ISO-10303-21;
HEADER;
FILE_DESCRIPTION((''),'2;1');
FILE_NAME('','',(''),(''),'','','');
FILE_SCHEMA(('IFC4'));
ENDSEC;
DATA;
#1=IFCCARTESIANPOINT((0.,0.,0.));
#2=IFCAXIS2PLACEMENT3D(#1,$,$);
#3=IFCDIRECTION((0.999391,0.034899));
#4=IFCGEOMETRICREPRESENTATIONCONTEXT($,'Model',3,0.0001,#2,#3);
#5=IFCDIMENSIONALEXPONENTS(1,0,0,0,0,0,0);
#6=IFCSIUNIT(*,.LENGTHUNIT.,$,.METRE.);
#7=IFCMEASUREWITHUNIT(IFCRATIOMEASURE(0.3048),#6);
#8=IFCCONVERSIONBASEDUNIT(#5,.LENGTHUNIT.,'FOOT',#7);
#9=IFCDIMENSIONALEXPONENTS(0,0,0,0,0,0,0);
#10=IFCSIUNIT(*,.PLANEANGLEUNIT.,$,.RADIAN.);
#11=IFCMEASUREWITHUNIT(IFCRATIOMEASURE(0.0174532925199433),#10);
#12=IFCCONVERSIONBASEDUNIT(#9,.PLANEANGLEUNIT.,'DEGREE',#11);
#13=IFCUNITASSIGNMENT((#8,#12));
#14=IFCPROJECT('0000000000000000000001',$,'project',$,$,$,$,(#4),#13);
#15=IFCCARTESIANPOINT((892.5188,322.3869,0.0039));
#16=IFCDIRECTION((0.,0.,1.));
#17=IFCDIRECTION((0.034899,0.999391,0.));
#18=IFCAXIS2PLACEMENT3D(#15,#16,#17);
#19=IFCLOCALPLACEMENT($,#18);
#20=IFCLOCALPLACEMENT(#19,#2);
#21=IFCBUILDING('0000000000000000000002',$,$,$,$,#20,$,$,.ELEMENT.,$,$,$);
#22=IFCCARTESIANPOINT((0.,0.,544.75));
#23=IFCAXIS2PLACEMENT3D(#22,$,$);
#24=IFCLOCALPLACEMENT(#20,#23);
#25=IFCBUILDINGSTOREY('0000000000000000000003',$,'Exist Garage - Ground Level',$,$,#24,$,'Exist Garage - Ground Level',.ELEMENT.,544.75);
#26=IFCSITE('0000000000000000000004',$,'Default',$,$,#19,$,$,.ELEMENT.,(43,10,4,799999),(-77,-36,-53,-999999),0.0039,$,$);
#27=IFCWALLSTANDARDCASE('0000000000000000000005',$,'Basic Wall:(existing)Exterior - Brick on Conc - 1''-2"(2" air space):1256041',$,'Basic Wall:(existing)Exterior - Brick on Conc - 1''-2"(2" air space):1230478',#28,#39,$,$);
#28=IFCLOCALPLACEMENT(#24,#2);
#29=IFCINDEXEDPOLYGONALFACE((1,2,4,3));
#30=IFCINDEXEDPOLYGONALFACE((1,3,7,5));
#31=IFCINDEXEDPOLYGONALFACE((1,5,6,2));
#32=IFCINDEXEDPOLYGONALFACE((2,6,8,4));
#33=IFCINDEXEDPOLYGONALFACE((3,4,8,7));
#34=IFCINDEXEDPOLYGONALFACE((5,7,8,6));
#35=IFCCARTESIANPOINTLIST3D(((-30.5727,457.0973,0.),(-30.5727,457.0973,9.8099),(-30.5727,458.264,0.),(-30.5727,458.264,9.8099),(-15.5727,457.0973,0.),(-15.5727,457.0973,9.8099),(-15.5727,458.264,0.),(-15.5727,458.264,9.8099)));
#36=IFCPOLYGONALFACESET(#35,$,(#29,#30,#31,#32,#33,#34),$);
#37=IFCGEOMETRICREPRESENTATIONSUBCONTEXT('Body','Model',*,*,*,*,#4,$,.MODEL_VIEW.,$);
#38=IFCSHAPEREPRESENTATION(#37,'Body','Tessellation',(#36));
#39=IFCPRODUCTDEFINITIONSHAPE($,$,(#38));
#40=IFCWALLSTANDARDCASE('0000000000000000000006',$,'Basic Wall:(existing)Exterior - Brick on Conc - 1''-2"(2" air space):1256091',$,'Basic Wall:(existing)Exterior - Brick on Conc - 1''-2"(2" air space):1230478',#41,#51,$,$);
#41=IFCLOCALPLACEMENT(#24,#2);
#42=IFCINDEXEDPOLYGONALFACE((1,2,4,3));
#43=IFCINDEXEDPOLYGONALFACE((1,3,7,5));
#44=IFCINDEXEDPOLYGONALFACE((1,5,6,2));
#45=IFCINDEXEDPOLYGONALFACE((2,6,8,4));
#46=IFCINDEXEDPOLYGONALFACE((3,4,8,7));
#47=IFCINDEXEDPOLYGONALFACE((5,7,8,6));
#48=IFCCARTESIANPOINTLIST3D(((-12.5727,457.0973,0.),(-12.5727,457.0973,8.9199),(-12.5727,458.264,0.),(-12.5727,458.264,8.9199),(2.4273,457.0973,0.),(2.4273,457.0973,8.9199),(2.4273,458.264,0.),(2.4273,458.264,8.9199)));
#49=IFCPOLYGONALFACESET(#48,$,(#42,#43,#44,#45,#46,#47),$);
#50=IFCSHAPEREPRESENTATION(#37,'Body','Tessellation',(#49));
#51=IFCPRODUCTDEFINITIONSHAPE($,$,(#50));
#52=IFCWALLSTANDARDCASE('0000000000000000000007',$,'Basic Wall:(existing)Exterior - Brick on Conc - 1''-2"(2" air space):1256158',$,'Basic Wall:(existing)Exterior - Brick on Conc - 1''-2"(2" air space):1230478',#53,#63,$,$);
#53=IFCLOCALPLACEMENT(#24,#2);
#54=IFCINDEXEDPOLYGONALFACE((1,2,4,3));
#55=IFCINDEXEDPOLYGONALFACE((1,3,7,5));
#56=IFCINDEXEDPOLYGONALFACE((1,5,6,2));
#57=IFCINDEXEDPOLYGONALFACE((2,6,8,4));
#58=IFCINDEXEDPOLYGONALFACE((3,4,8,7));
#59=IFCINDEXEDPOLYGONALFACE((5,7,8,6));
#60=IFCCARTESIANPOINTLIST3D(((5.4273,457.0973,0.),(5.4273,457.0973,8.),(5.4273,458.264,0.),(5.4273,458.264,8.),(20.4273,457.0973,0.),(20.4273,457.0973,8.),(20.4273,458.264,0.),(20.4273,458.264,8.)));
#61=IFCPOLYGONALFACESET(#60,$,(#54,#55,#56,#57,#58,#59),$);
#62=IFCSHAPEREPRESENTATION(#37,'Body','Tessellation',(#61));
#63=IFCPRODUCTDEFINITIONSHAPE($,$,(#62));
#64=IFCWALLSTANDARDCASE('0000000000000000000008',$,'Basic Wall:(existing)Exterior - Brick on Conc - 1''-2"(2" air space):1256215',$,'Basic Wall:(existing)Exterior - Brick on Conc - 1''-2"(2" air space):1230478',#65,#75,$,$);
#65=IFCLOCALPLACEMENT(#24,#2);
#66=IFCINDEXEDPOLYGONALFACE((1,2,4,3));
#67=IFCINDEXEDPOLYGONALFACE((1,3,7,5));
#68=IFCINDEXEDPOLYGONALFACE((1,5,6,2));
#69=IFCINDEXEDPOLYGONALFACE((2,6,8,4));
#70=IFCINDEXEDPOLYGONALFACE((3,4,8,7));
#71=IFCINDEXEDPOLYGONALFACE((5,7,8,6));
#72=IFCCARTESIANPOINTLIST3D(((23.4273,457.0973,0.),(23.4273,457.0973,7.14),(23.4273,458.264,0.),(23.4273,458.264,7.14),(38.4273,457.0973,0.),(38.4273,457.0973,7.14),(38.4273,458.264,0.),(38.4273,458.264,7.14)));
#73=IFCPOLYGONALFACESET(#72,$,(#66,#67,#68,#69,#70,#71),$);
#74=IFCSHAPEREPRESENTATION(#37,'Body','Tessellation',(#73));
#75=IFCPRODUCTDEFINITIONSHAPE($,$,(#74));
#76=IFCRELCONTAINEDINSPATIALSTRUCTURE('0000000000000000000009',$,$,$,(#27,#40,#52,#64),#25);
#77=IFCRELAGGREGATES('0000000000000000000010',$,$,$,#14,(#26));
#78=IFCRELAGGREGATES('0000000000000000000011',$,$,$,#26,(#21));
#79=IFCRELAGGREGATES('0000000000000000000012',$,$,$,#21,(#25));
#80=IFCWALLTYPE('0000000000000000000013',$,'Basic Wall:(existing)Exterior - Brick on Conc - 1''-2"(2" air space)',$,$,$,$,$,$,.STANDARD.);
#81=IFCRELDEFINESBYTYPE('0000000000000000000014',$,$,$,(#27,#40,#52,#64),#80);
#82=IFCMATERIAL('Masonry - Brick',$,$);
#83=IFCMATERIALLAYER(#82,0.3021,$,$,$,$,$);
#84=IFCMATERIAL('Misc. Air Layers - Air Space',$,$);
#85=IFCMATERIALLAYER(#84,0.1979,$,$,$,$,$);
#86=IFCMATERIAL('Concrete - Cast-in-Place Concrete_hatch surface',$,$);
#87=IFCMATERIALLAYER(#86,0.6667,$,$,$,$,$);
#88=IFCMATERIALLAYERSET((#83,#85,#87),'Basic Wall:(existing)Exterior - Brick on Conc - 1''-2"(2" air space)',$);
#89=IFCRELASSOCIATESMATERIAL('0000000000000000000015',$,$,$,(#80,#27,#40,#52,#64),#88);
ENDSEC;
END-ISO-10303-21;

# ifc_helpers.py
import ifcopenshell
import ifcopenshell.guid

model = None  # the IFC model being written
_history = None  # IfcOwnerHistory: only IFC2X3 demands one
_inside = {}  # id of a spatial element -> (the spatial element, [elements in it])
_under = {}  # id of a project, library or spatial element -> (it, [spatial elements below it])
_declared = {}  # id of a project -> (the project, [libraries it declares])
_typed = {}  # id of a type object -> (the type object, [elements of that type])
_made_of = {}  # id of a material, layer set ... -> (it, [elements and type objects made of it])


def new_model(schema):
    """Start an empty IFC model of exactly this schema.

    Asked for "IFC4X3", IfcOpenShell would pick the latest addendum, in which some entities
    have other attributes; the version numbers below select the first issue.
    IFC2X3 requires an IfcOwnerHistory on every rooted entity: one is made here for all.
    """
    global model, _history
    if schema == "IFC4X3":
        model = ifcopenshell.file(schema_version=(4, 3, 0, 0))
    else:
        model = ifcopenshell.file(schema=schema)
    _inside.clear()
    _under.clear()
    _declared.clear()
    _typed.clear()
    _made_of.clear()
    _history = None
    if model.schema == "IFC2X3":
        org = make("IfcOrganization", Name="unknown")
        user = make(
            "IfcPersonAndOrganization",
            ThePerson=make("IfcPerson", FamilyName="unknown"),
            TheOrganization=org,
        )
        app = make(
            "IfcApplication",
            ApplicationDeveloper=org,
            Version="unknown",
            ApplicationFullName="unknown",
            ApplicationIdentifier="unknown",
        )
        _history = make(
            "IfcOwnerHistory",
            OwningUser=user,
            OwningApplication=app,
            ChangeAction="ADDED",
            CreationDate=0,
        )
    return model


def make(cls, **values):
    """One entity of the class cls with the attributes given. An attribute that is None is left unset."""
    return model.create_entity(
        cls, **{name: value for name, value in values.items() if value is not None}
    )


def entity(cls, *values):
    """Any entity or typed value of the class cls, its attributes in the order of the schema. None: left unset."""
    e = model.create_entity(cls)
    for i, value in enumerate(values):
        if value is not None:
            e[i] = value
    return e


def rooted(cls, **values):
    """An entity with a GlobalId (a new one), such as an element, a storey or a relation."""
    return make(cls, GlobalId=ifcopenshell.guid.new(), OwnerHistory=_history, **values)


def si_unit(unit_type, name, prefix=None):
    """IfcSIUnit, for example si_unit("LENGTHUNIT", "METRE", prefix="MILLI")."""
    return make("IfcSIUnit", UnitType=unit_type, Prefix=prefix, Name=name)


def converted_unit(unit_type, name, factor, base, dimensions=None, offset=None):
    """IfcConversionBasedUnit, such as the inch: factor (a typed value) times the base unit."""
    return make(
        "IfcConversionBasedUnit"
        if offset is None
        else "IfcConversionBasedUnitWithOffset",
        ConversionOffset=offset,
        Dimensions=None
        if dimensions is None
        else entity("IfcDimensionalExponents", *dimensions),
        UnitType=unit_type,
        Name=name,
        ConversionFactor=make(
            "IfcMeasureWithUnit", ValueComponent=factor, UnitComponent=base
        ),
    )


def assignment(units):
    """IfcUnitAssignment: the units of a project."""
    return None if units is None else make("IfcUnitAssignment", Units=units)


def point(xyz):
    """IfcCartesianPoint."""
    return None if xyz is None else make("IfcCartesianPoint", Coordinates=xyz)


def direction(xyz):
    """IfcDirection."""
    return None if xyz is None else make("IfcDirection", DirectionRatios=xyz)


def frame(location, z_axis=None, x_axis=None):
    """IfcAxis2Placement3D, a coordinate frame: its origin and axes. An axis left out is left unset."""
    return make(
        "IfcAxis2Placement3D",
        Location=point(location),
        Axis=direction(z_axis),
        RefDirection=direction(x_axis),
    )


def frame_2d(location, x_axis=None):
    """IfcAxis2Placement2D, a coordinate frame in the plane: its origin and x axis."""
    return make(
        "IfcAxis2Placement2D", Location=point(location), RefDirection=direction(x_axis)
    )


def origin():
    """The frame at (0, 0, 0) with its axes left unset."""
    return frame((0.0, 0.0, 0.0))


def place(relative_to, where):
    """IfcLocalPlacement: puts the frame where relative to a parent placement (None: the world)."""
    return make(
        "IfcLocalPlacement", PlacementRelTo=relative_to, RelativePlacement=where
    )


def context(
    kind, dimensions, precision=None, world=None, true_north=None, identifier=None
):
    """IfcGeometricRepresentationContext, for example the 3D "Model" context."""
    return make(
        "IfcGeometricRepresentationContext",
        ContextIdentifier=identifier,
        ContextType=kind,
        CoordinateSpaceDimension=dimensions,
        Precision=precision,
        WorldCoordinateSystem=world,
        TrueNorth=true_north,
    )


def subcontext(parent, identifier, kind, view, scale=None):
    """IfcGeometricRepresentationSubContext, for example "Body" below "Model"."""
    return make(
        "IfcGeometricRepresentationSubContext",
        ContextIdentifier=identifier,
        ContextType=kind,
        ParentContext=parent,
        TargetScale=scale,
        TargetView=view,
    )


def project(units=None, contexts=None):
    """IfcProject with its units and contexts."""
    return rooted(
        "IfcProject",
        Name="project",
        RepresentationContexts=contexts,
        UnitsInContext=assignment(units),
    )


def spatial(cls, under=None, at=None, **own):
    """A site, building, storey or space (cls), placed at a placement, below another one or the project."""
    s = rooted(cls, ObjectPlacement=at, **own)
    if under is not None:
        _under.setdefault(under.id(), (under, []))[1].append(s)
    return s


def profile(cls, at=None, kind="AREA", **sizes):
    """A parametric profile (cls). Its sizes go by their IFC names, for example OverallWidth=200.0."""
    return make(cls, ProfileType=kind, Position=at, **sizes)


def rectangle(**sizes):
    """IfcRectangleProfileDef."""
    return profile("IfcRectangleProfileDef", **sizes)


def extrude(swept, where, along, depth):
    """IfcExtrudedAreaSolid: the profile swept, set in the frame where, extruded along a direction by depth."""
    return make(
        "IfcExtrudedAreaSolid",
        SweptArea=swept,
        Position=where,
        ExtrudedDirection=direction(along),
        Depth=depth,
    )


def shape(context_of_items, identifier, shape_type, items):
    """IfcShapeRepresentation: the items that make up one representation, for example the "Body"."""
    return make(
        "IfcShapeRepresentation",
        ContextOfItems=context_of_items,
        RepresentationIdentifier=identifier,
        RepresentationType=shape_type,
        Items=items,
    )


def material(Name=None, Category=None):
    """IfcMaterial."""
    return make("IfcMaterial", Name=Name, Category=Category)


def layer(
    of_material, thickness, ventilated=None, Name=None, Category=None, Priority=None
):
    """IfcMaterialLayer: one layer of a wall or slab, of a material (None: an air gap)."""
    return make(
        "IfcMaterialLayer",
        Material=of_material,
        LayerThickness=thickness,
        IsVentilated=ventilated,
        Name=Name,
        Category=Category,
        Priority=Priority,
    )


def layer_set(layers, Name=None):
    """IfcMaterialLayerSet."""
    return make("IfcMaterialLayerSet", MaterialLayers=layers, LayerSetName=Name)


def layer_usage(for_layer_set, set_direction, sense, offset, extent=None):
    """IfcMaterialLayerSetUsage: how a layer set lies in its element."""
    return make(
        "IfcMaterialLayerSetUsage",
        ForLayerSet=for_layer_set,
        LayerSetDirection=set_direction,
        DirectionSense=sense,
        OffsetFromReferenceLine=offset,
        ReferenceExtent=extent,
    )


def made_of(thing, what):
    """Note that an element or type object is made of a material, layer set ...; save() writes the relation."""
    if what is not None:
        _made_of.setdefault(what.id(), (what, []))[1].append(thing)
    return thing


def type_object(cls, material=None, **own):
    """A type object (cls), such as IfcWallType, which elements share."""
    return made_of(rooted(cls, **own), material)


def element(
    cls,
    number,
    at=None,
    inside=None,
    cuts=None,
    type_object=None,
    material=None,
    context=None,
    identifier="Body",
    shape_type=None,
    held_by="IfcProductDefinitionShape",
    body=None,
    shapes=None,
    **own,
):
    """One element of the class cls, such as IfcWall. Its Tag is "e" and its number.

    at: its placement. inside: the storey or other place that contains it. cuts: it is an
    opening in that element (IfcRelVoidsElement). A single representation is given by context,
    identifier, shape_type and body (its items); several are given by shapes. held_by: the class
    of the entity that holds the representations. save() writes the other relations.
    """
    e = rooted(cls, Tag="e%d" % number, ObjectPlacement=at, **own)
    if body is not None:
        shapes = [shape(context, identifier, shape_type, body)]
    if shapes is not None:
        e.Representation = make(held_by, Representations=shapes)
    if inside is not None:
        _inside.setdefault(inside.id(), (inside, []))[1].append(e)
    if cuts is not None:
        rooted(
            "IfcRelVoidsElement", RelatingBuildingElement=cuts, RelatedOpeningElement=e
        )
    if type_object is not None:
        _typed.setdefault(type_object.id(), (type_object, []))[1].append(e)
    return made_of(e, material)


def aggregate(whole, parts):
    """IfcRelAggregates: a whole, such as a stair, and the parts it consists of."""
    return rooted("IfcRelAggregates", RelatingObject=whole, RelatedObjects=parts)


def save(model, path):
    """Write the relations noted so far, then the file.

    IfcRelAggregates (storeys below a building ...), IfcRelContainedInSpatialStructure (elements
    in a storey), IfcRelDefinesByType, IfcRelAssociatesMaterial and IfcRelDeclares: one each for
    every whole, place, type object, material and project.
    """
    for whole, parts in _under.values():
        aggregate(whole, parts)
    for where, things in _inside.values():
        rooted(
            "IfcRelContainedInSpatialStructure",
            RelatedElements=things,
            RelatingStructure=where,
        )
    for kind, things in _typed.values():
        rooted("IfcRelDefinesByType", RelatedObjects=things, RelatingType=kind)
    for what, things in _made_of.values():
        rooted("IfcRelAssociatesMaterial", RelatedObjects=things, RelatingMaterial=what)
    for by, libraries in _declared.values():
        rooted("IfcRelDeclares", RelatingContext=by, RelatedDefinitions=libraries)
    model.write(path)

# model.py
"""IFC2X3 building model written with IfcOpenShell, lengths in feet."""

from ifc_helpers import new_model, entity, si_unit, converted_unit, direction, frame, frame_2d, origin, place, context, subcontext, project, spatial, rectangle, extrude, material, layer, layer_set, layer_usage, type_object, element, save


model = new_model("IFC2X3")

# Units and contexts
model_context = context("Model", 3, precision=0.0001, world=origin(), true_north=direction((0.999391, 0.034899)))
body_context = subcontext(model_context, "Body", "Model", "MODEL_VIEW")
ifc_project = project(units=[converted_unit("LENGTHUNIT", "FOOT", entity("IfcRatioMeasure", 0.3048), si_unit("LENGTHUNIT", "METRE"), dimensions=[1, 0, 0, 0, 0, 0, 0]), converted_unit("PLANEANGLEUNIT", "DEGREE", entity("IfcRatioMeasure", 0.0174532925199433), si_unit("PLANEANGLEUNIT", "RADIAN"), dimensions=[0, 0, 0, 0, 0, 0, 0])], contexts=[model_context])

# Site, building, storey
site_placement = place(None, frame((892.5188, 322.3869, 0.0039), z_axis=(0.0, 0.0, 1.0), x_axis=(0.034899, 0.999391, 0.0)))
site = spatial("IfcSite", under=ifc_project, at=site_placement, Name="Default", CompositionType="ELEMENT", RefLatitude=(43, 10, 4, 799999), RefLongitude=(-77, -36, -53, -999999), RefElevation=0.0039)
building_placement = place(site_placement, origin())
building = spatial("IfcBuilding", under=site, at=building_placement, CompositionType="ELEMENT")
storey_placement = place(building_placement, frame((0.0, 0.0, 544.75)))
storey = spatial("IfcBuildingStorey", under=building, at=storey_placement, Name="Exist Garage - Ground Level", LongName="Exist Garage - Ground Level", CompositionType="ELEMENT", Elevation=544.75)

# Walls
ifc_material_1 = material(Name="Masonry - Brick")
ifc_layer_1 = layer(ifc_material_1, 0.3021)
ifc_material_2 = material(Name="Misc. Air Layers - Air Space")
ifc_layer_2 = layer(ifc_material_2, 0.1979)
ifc_material_3 = material(Name="Concrete - Cast-in-Place Concrete_hatch surface")
ifc_layer_3 = layer(ifc_material_3, 0.6667)
ifc_layer_set_1 = layer_set([ifc_layer_1, ifc_layer_2, ifc_layer_3], Name="Basic Wall:(existing)Exterior - Brick on Conc - 1'-2\"(2\" air space)")
wall_type_1 = type_object("IfcWallType", Name="Basic Wall:(existing)Exterior - Brick on Conc - 1'-2\"(2\" air space)", PredefinedType="STANDARD", material=ifc_layer_set_1)
ifc_layer_usage_1 = layer_usage(ifc_layer_set_1, "AXIS2", "POSITIVE", -0.5833)
wall_1_placement = place(storey_placement, frame((-15.5727, 457.6806, 0.0), z_axis=(0.0, 0.0, 1.0), x_axis=(-1.0, 0.0, 0.0)))
element("IfcWallStandardCase", 1, at=wall_1_placement, inside=storey, type_object=wall_type_1, material=ifc_layer_usage_1, Name="Basic Wall:(existing)Exterior - Brick on Conc - 1'-2\"(2\" air space):1256041", ObjectType="Basic Wall:(existing)Exterior - Brick on Conc - 1'-2\"(2\" air space):1230478", context=body_context, shape_type="SweptSolid", body=[
    extrude(rectangle(XDim=15.0, YDim=1.1667, at=frame_2d((7.5, 0.0), x_axis=(-1.0, 0.0))), origin(), (0.0, 0.0, 1.0), 9.8099),
])
ifc_layer_usage_2 = layer_usage(ifc_layer_set_1, "AXIS2", "POSITIVE", -0.5833)
wall_2_placement = place(storey_placement, frame((2.4273, 457.6806, 0.0), z_axis=(0.0, 0.0, 1.0), x_axis=(-1.0, 0.0, 0.0)))
element("IfcWallStandardCase", 2, at=wall_2_placement, inside=storey, type_object=wall_type_1, material=ifc_layer_usage_2, Name="Basic Wall:(existing)Exterior - Brick on Conc - 1'-2\"(2\" air space):1256091", ObjectType="Basic Wall:(existing)Exterior - Brick on Conc - 1'-2\"(2\" air space):1230478", context=body_context, shape_type="SweptSolid", body=[
    extrude(rectangle(XDim=15.0, YDim=1.1667, at=frame_2d((7.5, 0.0), x_axis=(-1.0, 0.0))), origin(), (0.0, 0.0, 1.0), 8.9199),
])
ifc_layer_usage_3 = layer_usage(ifc_layer_set_1, "AXIS2", "POSITIVE", -0.5833)
wall_3_placement = place(storey_placement, frame((20.4273, 457.6806, 0.0), z_axis=(0.0, 0.0, 1.0), x_axis=(-1.0, 0.0, 0.0)))
element("IfcWallStandardCase", 3, at=wall_3_placement, inside=storey, type_object=wall_type_1, material=ifc_layer_usage_3, Name="Basic Wall:(existing)Exterior - Brick on Conc - 1'-2\"(2\" air space):1256158", ObjectType="Basic Wall:(existing)Exterior - Brick on Conc - 1'-2\"(2\" air space):1230478", context=body_context, shape_type="SweptSolid", body=[
    extrude(rectangle(XDim=15.0, YDim=1.1667, at=frame_2d((7.5, 0.0), x_axis=(-1.0, 0.0))), origin(), (0.0, 0.0, 1.0), 8.0),
])
ifc_layer_usage_4 = layer_usage(ifc_layer_set_1, "AXIS2", "POSITIVE", -0.5833)
wall_4_placement = place(storey_placement, frame((38.4273, 457.6806, 0.0), z_axis=(0.0, 0.0, 1.0), x_axis=(-1.0, 0.0, 0.0)))
element("IfcWallStandardCase", 4, at=wall_4_placement, inside=storey, type_object=wall_type_1, material=ifc_layer_usage_4, Name="Basic Wall:(existing)Exterior - Brick on Conc - 1'-2\"(2\" air space):1256215", ObjectType="Basic Wall:(existing)Exterior - Brick on Conc - 1'-2\"(2\" air space):1230478", context=body_context, shape_type="SweptSolid", body=[
    extrude(rectangle(XDim=15.0, YDim=1.1667, at=frame_2d((7.5, 0.0), x_axis=(-1.0, 0.0))), origin(), (0.0, 0.0, 1.0), 7.14),
])

save(model, "model.ifc")
